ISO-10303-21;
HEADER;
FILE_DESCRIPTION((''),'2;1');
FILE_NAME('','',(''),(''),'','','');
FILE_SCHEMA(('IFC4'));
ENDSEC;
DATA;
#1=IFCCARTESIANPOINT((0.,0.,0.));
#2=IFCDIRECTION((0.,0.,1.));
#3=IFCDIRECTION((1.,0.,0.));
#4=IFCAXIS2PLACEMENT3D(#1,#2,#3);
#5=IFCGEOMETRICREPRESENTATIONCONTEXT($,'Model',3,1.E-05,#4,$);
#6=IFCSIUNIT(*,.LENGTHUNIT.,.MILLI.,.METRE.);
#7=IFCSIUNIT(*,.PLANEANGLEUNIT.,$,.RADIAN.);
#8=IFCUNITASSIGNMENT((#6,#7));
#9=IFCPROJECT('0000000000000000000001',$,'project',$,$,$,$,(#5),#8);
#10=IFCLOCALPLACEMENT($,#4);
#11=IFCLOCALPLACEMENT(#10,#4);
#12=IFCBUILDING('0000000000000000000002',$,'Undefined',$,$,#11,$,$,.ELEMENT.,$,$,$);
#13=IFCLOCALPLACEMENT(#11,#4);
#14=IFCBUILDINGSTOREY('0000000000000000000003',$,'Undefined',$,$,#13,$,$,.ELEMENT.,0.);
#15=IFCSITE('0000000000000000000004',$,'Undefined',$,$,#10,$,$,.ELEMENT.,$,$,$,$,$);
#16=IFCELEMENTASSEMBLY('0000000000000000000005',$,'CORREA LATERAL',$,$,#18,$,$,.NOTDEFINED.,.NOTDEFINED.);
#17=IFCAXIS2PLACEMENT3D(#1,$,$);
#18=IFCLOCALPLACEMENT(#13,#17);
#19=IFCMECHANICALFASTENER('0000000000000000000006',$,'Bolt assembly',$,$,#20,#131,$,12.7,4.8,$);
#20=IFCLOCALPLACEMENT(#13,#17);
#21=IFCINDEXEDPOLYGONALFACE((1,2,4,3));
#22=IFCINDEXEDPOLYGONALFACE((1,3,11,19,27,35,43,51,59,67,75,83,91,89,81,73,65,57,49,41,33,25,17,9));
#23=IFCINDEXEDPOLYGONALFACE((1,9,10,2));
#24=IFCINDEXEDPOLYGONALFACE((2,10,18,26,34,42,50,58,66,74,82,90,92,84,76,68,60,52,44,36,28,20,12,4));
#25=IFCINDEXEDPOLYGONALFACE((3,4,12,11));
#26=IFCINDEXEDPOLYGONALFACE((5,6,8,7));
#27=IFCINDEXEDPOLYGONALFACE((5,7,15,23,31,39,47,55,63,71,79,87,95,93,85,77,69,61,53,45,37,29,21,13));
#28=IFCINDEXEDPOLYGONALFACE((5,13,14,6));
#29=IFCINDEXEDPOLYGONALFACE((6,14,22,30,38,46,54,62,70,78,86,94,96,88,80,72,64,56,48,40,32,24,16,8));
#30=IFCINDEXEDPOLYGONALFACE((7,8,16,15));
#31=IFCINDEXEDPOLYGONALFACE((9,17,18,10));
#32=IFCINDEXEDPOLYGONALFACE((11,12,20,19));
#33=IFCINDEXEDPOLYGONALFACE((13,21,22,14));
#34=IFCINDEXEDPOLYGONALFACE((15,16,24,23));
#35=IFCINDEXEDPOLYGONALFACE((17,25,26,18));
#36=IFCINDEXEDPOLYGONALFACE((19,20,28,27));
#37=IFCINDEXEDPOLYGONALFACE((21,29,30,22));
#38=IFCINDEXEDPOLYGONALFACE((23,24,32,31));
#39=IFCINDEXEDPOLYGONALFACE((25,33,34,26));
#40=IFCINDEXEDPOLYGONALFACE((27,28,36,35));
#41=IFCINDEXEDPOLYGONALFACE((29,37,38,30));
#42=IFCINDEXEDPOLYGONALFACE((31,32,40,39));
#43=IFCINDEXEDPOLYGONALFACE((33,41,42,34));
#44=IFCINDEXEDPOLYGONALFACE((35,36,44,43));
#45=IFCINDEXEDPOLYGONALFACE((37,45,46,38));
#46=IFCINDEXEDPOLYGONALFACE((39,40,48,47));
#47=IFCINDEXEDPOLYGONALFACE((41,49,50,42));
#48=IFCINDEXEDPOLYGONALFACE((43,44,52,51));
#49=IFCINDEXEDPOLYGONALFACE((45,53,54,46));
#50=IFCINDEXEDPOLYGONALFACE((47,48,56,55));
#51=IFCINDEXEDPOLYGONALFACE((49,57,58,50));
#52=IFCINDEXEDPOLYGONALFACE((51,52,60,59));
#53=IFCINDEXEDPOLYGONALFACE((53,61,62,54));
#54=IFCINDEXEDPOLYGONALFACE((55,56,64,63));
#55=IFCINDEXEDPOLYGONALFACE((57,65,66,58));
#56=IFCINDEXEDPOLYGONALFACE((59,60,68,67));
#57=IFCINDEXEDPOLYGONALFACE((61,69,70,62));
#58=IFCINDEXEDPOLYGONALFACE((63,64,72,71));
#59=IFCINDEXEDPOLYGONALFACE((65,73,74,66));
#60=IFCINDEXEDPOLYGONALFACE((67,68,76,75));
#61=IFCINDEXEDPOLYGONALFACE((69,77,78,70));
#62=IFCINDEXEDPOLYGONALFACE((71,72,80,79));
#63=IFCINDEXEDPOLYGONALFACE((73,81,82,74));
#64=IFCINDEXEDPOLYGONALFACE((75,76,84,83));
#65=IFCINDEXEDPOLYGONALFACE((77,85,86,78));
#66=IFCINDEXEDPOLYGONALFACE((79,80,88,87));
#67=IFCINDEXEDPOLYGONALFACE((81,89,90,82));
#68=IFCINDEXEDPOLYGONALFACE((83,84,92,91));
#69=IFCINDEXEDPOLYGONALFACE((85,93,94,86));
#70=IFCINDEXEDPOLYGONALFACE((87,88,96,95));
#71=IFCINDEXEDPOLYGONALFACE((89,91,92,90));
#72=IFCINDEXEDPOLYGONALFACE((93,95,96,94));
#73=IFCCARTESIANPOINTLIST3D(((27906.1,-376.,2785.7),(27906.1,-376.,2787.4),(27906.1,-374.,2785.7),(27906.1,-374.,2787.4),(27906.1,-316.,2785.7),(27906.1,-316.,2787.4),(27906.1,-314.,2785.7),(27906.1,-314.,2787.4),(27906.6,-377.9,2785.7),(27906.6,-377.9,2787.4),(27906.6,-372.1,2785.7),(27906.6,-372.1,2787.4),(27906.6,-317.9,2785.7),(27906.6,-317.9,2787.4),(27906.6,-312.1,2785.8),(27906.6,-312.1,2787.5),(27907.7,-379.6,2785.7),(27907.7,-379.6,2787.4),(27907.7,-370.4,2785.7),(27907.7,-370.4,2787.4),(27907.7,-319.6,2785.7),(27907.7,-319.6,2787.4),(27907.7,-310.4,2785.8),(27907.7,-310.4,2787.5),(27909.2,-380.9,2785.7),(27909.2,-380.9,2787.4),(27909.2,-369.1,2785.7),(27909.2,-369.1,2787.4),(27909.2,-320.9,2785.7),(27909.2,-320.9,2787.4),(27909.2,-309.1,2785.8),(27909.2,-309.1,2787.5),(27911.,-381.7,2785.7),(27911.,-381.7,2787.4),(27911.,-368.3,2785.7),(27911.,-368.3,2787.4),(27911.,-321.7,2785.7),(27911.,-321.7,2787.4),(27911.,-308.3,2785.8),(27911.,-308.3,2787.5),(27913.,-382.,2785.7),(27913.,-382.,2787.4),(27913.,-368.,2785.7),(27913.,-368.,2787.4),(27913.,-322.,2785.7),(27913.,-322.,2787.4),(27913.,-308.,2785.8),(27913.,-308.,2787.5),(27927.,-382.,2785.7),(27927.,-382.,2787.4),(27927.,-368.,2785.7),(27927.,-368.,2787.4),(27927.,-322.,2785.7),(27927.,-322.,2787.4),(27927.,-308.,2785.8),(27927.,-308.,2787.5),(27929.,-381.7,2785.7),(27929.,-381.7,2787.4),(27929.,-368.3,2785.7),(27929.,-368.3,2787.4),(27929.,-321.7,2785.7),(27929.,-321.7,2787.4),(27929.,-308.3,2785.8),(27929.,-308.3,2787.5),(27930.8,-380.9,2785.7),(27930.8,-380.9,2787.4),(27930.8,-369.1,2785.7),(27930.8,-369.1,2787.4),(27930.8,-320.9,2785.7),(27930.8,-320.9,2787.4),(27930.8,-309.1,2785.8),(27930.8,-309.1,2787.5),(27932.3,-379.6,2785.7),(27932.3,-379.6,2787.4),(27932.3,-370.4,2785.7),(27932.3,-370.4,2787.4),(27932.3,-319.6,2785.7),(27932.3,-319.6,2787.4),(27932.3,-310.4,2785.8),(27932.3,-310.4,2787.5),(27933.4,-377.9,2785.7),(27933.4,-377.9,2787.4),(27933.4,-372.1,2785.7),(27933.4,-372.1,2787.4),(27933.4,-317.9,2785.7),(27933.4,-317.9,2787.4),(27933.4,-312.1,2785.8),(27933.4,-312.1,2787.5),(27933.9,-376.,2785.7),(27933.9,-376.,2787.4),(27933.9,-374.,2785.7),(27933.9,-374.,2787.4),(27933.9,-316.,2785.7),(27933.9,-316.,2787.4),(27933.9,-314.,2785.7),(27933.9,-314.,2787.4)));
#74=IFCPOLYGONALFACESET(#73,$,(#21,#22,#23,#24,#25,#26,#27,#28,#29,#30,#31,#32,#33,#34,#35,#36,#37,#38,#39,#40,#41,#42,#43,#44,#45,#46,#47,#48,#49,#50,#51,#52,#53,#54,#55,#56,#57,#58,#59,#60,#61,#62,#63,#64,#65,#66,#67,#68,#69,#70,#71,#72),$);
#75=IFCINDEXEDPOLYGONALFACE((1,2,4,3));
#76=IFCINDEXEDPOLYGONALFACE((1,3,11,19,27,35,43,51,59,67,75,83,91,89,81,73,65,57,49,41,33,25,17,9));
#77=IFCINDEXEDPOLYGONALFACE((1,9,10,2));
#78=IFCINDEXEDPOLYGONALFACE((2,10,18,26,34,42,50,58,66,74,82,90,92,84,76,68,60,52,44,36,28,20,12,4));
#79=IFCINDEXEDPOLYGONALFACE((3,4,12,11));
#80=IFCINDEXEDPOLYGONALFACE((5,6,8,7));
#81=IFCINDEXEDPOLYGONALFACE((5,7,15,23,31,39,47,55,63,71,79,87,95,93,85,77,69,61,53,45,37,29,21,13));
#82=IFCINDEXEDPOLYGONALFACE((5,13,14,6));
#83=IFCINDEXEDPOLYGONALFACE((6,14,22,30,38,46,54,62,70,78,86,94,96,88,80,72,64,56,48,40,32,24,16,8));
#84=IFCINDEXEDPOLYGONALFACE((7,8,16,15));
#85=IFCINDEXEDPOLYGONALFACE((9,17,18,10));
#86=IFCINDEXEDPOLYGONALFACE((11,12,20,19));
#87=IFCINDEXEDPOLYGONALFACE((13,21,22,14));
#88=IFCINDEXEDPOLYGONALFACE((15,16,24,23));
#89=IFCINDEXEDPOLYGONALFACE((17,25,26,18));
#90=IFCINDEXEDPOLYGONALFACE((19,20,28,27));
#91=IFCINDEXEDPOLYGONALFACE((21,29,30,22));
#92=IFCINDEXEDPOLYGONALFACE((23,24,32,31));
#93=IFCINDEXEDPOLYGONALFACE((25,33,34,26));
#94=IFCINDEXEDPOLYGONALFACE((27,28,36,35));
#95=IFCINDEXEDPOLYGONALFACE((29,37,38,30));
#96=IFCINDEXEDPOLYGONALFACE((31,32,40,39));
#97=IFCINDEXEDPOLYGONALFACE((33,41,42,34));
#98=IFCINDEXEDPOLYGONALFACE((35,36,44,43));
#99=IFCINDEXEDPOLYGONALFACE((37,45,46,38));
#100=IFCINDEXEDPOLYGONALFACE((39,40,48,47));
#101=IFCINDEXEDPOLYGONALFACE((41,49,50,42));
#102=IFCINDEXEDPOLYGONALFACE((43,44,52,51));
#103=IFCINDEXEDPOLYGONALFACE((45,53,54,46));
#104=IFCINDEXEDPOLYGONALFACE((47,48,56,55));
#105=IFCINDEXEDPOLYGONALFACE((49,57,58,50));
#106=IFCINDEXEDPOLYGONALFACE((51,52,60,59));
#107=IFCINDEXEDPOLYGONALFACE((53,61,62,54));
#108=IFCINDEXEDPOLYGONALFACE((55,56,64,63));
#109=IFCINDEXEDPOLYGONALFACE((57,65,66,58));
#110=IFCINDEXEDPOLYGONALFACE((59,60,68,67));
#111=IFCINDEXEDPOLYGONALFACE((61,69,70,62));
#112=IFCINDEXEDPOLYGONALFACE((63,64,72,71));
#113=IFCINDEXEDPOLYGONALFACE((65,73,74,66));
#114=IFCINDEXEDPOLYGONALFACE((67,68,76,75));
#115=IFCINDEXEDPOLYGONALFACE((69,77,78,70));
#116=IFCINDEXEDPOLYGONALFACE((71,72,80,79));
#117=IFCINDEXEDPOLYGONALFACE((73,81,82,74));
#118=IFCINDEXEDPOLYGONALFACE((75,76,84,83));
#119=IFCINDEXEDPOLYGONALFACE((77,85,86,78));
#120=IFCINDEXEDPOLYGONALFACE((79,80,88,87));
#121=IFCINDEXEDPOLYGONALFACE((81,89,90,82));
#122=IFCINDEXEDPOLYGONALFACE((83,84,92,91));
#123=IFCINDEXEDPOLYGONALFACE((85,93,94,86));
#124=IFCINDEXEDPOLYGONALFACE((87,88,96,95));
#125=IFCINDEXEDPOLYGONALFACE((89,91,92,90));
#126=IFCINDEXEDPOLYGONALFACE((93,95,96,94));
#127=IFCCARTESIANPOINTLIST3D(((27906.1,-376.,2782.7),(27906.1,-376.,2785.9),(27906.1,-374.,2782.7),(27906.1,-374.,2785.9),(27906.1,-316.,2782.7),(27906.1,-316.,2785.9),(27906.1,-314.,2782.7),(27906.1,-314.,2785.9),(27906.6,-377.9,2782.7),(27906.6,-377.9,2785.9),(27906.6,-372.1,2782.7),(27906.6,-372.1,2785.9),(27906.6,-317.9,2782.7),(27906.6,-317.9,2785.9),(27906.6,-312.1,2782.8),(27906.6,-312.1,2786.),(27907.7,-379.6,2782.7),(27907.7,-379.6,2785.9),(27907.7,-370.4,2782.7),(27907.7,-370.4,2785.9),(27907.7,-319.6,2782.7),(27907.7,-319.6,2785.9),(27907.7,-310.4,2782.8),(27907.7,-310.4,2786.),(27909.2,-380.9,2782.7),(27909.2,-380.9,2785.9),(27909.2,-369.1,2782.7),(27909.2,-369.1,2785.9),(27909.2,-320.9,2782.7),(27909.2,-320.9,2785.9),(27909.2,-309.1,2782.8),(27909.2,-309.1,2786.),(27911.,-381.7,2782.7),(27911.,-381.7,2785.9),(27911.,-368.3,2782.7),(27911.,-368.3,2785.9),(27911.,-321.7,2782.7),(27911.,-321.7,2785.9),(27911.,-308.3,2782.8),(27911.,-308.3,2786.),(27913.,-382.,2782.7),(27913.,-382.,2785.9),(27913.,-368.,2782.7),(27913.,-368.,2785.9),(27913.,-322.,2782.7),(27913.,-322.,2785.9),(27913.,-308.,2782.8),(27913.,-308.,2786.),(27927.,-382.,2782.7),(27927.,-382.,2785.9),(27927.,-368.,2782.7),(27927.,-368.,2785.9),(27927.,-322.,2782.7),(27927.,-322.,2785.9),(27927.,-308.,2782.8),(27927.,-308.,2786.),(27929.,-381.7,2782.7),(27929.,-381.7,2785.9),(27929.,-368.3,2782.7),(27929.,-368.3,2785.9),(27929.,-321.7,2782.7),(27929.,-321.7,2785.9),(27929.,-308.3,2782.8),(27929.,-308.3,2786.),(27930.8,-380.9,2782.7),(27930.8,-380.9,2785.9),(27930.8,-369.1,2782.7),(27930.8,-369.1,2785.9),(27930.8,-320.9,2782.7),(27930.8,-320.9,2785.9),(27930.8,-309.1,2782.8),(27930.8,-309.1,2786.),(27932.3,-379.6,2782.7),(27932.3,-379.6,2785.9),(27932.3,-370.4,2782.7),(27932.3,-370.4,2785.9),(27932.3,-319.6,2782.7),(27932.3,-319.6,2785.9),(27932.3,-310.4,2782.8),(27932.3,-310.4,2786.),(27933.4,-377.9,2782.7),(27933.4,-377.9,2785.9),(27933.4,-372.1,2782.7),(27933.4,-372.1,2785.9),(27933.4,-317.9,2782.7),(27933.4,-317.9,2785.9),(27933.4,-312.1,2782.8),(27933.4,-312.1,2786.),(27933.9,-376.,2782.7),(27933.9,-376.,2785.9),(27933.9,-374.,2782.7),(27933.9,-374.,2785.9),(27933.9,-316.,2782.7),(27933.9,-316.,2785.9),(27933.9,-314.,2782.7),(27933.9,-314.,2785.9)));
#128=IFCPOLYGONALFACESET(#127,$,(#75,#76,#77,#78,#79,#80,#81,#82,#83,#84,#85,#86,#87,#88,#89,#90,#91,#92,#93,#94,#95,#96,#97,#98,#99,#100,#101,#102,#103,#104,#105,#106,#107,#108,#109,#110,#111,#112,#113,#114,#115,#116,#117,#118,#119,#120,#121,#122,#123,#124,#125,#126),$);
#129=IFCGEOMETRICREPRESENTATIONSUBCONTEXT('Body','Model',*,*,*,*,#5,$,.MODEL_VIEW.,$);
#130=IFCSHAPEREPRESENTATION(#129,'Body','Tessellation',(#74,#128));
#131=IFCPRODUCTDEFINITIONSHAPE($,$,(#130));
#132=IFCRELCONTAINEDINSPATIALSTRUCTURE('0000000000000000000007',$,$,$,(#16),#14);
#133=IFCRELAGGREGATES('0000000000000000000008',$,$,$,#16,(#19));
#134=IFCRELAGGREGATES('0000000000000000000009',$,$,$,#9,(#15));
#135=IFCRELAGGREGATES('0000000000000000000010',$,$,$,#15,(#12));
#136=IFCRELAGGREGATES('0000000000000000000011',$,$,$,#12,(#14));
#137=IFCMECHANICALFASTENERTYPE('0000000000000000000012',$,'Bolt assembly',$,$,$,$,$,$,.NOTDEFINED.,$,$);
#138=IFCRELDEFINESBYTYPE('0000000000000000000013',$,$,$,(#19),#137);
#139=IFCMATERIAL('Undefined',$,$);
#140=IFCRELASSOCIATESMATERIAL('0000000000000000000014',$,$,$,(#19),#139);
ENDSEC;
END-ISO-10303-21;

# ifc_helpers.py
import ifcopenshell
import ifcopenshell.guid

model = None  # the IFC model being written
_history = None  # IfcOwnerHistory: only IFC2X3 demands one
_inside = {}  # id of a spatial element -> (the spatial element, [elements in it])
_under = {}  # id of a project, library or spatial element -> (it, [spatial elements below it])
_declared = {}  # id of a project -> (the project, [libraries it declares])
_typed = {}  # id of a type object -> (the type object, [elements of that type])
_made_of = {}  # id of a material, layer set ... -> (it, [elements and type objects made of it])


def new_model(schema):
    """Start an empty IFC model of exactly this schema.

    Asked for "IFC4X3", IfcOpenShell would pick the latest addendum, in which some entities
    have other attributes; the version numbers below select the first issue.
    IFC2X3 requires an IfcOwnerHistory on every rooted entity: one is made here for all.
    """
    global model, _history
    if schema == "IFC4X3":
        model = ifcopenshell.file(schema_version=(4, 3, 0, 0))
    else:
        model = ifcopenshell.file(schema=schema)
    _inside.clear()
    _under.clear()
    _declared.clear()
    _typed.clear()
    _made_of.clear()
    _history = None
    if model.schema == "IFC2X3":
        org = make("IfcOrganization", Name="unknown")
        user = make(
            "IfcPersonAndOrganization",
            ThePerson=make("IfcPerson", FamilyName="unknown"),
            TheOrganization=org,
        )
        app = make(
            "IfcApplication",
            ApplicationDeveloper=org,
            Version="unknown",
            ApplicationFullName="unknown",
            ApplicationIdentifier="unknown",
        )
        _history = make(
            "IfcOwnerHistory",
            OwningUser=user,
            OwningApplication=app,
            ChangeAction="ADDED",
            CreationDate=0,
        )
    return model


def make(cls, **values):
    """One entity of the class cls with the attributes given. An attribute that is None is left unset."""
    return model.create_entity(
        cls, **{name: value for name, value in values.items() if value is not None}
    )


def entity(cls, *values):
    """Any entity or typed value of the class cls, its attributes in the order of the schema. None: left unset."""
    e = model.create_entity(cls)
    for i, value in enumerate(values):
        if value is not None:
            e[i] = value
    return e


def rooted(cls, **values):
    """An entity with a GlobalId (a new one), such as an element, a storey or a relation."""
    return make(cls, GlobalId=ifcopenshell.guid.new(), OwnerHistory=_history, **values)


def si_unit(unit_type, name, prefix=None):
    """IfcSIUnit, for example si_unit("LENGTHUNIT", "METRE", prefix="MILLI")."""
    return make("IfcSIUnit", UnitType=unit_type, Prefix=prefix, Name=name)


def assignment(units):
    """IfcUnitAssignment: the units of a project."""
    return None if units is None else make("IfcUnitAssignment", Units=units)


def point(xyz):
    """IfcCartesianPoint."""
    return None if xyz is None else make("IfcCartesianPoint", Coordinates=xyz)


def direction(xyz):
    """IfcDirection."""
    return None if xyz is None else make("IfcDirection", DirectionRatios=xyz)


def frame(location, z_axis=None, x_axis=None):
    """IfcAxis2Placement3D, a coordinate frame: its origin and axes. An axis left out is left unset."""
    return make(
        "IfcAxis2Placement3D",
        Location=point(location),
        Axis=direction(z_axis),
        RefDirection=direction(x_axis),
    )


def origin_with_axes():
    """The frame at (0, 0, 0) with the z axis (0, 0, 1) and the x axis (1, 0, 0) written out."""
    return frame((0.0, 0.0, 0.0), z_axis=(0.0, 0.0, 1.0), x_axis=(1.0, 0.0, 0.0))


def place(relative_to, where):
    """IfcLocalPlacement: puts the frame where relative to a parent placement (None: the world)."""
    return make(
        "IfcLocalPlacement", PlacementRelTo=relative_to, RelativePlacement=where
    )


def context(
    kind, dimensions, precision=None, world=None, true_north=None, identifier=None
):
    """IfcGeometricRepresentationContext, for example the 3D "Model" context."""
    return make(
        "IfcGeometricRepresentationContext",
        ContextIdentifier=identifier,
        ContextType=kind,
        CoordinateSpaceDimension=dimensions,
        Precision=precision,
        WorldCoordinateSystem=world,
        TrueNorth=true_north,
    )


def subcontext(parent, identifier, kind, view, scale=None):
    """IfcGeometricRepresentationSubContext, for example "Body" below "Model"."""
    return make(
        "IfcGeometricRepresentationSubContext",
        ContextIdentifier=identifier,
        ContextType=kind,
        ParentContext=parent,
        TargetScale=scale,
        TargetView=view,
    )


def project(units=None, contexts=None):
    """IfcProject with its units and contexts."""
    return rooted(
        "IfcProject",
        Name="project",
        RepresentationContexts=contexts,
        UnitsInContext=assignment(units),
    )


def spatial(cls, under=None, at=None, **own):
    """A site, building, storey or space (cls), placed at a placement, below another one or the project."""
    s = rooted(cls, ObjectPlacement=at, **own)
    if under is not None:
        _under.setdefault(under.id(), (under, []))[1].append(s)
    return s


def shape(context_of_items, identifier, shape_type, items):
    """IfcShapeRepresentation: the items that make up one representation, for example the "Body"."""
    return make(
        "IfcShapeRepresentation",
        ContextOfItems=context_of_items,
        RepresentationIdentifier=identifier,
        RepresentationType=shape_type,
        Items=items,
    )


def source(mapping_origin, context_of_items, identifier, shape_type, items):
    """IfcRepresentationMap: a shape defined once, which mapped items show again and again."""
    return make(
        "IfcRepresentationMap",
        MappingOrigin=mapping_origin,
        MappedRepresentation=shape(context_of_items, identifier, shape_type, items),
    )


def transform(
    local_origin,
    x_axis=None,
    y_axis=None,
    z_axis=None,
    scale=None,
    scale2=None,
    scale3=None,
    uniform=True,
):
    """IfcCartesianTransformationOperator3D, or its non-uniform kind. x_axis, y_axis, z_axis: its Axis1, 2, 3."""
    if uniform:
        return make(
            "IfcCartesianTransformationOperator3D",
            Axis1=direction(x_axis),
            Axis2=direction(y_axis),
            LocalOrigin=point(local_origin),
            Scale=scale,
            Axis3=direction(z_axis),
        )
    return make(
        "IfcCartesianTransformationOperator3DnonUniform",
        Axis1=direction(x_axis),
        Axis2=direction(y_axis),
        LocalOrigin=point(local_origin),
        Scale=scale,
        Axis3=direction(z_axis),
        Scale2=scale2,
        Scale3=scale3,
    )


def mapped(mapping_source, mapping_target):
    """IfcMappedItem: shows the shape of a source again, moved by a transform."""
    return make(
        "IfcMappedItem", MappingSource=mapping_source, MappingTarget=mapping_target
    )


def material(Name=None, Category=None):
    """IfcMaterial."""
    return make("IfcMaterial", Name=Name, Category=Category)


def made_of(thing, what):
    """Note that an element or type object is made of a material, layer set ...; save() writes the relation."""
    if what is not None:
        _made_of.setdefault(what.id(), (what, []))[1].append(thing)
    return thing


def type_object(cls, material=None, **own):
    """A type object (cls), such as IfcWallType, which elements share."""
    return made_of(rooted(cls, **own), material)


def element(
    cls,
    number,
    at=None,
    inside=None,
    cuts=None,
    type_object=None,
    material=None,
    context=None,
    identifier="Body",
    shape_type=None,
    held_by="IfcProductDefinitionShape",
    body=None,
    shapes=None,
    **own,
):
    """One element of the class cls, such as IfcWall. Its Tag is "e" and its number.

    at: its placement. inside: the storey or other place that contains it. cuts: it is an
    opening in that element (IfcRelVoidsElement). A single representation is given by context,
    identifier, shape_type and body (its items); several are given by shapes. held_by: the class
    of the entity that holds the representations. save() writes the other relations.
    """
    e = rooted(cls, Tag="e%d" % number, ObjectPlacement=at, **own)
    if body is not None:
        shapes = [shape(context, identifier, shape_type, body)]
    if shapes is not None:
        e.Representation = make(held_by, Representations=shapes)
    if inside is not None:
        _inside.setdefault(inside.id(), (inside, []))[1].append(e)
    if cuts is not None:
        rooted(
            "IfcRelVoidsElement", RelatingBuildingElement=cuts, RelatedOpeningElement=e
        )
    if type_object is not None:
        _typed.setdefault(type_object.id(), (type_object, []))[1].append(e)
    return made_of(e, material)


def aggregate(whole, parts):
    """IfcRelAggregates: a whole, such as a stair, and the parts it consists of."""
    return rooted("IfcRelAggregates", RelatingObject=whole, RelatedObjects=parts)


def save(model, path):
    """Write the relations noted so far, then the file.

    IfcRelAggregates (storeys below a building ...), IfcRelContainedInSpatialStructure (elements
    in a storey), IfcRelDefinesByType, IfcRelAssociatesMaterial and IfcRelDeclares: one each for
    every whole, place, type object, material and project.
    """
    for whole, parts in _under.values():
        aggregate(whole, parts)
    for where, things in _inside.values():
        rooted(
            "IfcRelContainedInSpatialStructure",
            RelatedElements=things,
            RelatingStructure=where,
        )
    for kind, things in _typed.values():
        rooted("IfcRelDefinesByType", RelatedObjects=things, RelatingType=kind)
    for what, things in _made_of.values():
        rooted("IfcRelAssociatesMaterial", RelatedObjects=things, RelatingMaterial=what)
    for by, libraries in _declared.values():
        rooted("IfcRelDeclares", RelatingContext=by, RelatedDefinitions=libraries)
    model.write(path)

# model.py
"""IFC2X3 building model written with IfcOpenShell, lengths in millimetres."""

from ifc_helpers import new_model, entity, si_unit, frame, origin_with_axes, place, context, subcontext, project, spatial, source, transform, mapped, material, type_object, element, aggregate, save


model = new_model("IFC2X3")

# Units and contexts
model_context = context("Model", 3, precision=1e-05, world=origin_with_axes())
body_context = subcontext(model_context, "Body", "Model", "MODEL_VIEW")
ifc_project = project(units=[si_unit("LENGTHUNIT", "METRE", prefix="MILLI"), si_unit("PLANEANGLEUNIT", "RADIAN")], contexts=[model_context])

# Site, building, storey
site_placement = place(None, origin_with_axes())
site = spatial("IfcSite", under=ifc_project, at=site_placement, Name="Undefined", CompositionType="ELEMENT")
building_placement = place(site_placement, origin_with_axes())
building = spatial("IfcBuilding", under=site, at=building_placement, Name="Undefined", CompositionType="ELEMENT")
storey_placement = place(building_placement, origin_with_axes())
storey = spatial("IfcBuildingStorey", under=building, at=storey_placement, Name="Undefined", CompositionType="ELEMENT", Elevation=0.0)

# Shared definitions
ifc_material_1 = material(Name="Undefined")
mechanical_fastener_type = type_object("IfcMechanicalFastenerType", Name="Bolt assembly")

# Element assembly, mechanical fastener
assembly_1_placement = place(storey_placement, origin_with_axes())
assembly_1 = element("IfcElementAssembly", 1, at=assembly_1_placement, inside=storey, Name="CORREA LATERAL", AssemblyPlace="NOTDEFINED", PredefinedType="NOTDEFINED")
shared_circle_1 = entity("IfcCircle", entity("IfcAxis2Placement2D", entity("IfcCartesianPoint", [0.0, -7.0]), entity("IfcDirection", [1.0, 0.0])), 7.0)
shared_circle_2 = entity("IfcCircle", entity("IfcAxis2Placement2D", entity("IfcCartesianPoint", [0.0, 7.0]), entity("IfcDirection", [-1.0, 0.0])), 7.0)
shared_composite_curve = entity("IfcCompositeCurve", [entity("IfcCompositeCurveSegment", "CONTINUOUS", True, entity("IfcPolyline", [entity("IfcCartesianPoint", [7.0, 7.0]), entity("IfcCartesianPoint", [7.0, -7.0])])), entity("IfcCompositeCurveSegment", "CONTINUOUS", True, entity("IfcTrimmedCurve", shared_circle_1, [entity("IfcParameterValue", 0.0)], [entity("IfcParameterValue", 3.141593)], False, "PARAMETER")), entity("IfcCompositeCurveSegment", "CONTINUOUS", True, entity("IfcPolyline", [entity("IfcCartesianPoint", [-7.0, -7.0]), entity("IfcCartesianPoint", [-7.0, 7.0])])), entity("IfcCompositeCurveSegment", "DISCONTINUOUS", True, entity("IfcTrimmedCurve", shared_circle_2, [entity("IfcParameterValue", 0.0)], [entity("IfcParameterValue", 3.141593)], False, "PARAMETER"))], False)
shared_shape_1 = source(origin_with_axes(), body_context, "Body", "SweptSolid", [
    entity("IfcExtrudedAreaSolid", entity("IfcArbitraryClosedProfileDef", "AREA", None, shared_composite_curve), entity("IfcAxis2Placement3D", entity("IfcCartesianPoint", [0.0, 3.1, 0.0]), entity("IfcDirection", [0.0, 1.0, 0.0]), entity("IfcDirection", [1.0, 0.0, 0.0])), entity("IfcDirection", [0.0, 0.0, 1.0]), 1.7),
    entity("IfcExtrudedAreaSolid", entity("IfcArbitraryClosedProfileDef", "AREA", None, shared_composite_curve), entity("IfcAxis2Placement3D", entity("IfcCartesianPoint", [0.0, 0.1, 0.0]), entity("IfcDirection", [0.0, 1.0, 0.0]), entity("IfcDirection", [1.0, 0.0, 0.0])), entity("IfcDirection", [0.0, 0.0, 1.0]), 3.2),
])
mechanical_fastener_1_placement = place(assembly_1_placement, frame((27920.0, -375.0, 2782.6), z_axis=(1.0, 0.0, 0.0), x_axis=(0.0, 1.0, 0.000007)))
mechanical_fastener_1 = element("IfcMechanicalFastener", 2, at=mechanical_fastener_1_placement, type_object=mechanical_fastener_type, material=ifc_material_1, Name="Bolt assembly", NominalDiameter=12.7, NominalLength=4.8, context=body_context, shape_type="MappedRepresentation", body=[
    mapped(shared_shape_1, transform((0.0, 0.0, 0.0))),
    mapped(shared_shape_1, transform((60.0, 0.0, 0.0))),
])
aggregate(assembly_1, [mechanical_fastener_1])

save(model, "model.ifc")
